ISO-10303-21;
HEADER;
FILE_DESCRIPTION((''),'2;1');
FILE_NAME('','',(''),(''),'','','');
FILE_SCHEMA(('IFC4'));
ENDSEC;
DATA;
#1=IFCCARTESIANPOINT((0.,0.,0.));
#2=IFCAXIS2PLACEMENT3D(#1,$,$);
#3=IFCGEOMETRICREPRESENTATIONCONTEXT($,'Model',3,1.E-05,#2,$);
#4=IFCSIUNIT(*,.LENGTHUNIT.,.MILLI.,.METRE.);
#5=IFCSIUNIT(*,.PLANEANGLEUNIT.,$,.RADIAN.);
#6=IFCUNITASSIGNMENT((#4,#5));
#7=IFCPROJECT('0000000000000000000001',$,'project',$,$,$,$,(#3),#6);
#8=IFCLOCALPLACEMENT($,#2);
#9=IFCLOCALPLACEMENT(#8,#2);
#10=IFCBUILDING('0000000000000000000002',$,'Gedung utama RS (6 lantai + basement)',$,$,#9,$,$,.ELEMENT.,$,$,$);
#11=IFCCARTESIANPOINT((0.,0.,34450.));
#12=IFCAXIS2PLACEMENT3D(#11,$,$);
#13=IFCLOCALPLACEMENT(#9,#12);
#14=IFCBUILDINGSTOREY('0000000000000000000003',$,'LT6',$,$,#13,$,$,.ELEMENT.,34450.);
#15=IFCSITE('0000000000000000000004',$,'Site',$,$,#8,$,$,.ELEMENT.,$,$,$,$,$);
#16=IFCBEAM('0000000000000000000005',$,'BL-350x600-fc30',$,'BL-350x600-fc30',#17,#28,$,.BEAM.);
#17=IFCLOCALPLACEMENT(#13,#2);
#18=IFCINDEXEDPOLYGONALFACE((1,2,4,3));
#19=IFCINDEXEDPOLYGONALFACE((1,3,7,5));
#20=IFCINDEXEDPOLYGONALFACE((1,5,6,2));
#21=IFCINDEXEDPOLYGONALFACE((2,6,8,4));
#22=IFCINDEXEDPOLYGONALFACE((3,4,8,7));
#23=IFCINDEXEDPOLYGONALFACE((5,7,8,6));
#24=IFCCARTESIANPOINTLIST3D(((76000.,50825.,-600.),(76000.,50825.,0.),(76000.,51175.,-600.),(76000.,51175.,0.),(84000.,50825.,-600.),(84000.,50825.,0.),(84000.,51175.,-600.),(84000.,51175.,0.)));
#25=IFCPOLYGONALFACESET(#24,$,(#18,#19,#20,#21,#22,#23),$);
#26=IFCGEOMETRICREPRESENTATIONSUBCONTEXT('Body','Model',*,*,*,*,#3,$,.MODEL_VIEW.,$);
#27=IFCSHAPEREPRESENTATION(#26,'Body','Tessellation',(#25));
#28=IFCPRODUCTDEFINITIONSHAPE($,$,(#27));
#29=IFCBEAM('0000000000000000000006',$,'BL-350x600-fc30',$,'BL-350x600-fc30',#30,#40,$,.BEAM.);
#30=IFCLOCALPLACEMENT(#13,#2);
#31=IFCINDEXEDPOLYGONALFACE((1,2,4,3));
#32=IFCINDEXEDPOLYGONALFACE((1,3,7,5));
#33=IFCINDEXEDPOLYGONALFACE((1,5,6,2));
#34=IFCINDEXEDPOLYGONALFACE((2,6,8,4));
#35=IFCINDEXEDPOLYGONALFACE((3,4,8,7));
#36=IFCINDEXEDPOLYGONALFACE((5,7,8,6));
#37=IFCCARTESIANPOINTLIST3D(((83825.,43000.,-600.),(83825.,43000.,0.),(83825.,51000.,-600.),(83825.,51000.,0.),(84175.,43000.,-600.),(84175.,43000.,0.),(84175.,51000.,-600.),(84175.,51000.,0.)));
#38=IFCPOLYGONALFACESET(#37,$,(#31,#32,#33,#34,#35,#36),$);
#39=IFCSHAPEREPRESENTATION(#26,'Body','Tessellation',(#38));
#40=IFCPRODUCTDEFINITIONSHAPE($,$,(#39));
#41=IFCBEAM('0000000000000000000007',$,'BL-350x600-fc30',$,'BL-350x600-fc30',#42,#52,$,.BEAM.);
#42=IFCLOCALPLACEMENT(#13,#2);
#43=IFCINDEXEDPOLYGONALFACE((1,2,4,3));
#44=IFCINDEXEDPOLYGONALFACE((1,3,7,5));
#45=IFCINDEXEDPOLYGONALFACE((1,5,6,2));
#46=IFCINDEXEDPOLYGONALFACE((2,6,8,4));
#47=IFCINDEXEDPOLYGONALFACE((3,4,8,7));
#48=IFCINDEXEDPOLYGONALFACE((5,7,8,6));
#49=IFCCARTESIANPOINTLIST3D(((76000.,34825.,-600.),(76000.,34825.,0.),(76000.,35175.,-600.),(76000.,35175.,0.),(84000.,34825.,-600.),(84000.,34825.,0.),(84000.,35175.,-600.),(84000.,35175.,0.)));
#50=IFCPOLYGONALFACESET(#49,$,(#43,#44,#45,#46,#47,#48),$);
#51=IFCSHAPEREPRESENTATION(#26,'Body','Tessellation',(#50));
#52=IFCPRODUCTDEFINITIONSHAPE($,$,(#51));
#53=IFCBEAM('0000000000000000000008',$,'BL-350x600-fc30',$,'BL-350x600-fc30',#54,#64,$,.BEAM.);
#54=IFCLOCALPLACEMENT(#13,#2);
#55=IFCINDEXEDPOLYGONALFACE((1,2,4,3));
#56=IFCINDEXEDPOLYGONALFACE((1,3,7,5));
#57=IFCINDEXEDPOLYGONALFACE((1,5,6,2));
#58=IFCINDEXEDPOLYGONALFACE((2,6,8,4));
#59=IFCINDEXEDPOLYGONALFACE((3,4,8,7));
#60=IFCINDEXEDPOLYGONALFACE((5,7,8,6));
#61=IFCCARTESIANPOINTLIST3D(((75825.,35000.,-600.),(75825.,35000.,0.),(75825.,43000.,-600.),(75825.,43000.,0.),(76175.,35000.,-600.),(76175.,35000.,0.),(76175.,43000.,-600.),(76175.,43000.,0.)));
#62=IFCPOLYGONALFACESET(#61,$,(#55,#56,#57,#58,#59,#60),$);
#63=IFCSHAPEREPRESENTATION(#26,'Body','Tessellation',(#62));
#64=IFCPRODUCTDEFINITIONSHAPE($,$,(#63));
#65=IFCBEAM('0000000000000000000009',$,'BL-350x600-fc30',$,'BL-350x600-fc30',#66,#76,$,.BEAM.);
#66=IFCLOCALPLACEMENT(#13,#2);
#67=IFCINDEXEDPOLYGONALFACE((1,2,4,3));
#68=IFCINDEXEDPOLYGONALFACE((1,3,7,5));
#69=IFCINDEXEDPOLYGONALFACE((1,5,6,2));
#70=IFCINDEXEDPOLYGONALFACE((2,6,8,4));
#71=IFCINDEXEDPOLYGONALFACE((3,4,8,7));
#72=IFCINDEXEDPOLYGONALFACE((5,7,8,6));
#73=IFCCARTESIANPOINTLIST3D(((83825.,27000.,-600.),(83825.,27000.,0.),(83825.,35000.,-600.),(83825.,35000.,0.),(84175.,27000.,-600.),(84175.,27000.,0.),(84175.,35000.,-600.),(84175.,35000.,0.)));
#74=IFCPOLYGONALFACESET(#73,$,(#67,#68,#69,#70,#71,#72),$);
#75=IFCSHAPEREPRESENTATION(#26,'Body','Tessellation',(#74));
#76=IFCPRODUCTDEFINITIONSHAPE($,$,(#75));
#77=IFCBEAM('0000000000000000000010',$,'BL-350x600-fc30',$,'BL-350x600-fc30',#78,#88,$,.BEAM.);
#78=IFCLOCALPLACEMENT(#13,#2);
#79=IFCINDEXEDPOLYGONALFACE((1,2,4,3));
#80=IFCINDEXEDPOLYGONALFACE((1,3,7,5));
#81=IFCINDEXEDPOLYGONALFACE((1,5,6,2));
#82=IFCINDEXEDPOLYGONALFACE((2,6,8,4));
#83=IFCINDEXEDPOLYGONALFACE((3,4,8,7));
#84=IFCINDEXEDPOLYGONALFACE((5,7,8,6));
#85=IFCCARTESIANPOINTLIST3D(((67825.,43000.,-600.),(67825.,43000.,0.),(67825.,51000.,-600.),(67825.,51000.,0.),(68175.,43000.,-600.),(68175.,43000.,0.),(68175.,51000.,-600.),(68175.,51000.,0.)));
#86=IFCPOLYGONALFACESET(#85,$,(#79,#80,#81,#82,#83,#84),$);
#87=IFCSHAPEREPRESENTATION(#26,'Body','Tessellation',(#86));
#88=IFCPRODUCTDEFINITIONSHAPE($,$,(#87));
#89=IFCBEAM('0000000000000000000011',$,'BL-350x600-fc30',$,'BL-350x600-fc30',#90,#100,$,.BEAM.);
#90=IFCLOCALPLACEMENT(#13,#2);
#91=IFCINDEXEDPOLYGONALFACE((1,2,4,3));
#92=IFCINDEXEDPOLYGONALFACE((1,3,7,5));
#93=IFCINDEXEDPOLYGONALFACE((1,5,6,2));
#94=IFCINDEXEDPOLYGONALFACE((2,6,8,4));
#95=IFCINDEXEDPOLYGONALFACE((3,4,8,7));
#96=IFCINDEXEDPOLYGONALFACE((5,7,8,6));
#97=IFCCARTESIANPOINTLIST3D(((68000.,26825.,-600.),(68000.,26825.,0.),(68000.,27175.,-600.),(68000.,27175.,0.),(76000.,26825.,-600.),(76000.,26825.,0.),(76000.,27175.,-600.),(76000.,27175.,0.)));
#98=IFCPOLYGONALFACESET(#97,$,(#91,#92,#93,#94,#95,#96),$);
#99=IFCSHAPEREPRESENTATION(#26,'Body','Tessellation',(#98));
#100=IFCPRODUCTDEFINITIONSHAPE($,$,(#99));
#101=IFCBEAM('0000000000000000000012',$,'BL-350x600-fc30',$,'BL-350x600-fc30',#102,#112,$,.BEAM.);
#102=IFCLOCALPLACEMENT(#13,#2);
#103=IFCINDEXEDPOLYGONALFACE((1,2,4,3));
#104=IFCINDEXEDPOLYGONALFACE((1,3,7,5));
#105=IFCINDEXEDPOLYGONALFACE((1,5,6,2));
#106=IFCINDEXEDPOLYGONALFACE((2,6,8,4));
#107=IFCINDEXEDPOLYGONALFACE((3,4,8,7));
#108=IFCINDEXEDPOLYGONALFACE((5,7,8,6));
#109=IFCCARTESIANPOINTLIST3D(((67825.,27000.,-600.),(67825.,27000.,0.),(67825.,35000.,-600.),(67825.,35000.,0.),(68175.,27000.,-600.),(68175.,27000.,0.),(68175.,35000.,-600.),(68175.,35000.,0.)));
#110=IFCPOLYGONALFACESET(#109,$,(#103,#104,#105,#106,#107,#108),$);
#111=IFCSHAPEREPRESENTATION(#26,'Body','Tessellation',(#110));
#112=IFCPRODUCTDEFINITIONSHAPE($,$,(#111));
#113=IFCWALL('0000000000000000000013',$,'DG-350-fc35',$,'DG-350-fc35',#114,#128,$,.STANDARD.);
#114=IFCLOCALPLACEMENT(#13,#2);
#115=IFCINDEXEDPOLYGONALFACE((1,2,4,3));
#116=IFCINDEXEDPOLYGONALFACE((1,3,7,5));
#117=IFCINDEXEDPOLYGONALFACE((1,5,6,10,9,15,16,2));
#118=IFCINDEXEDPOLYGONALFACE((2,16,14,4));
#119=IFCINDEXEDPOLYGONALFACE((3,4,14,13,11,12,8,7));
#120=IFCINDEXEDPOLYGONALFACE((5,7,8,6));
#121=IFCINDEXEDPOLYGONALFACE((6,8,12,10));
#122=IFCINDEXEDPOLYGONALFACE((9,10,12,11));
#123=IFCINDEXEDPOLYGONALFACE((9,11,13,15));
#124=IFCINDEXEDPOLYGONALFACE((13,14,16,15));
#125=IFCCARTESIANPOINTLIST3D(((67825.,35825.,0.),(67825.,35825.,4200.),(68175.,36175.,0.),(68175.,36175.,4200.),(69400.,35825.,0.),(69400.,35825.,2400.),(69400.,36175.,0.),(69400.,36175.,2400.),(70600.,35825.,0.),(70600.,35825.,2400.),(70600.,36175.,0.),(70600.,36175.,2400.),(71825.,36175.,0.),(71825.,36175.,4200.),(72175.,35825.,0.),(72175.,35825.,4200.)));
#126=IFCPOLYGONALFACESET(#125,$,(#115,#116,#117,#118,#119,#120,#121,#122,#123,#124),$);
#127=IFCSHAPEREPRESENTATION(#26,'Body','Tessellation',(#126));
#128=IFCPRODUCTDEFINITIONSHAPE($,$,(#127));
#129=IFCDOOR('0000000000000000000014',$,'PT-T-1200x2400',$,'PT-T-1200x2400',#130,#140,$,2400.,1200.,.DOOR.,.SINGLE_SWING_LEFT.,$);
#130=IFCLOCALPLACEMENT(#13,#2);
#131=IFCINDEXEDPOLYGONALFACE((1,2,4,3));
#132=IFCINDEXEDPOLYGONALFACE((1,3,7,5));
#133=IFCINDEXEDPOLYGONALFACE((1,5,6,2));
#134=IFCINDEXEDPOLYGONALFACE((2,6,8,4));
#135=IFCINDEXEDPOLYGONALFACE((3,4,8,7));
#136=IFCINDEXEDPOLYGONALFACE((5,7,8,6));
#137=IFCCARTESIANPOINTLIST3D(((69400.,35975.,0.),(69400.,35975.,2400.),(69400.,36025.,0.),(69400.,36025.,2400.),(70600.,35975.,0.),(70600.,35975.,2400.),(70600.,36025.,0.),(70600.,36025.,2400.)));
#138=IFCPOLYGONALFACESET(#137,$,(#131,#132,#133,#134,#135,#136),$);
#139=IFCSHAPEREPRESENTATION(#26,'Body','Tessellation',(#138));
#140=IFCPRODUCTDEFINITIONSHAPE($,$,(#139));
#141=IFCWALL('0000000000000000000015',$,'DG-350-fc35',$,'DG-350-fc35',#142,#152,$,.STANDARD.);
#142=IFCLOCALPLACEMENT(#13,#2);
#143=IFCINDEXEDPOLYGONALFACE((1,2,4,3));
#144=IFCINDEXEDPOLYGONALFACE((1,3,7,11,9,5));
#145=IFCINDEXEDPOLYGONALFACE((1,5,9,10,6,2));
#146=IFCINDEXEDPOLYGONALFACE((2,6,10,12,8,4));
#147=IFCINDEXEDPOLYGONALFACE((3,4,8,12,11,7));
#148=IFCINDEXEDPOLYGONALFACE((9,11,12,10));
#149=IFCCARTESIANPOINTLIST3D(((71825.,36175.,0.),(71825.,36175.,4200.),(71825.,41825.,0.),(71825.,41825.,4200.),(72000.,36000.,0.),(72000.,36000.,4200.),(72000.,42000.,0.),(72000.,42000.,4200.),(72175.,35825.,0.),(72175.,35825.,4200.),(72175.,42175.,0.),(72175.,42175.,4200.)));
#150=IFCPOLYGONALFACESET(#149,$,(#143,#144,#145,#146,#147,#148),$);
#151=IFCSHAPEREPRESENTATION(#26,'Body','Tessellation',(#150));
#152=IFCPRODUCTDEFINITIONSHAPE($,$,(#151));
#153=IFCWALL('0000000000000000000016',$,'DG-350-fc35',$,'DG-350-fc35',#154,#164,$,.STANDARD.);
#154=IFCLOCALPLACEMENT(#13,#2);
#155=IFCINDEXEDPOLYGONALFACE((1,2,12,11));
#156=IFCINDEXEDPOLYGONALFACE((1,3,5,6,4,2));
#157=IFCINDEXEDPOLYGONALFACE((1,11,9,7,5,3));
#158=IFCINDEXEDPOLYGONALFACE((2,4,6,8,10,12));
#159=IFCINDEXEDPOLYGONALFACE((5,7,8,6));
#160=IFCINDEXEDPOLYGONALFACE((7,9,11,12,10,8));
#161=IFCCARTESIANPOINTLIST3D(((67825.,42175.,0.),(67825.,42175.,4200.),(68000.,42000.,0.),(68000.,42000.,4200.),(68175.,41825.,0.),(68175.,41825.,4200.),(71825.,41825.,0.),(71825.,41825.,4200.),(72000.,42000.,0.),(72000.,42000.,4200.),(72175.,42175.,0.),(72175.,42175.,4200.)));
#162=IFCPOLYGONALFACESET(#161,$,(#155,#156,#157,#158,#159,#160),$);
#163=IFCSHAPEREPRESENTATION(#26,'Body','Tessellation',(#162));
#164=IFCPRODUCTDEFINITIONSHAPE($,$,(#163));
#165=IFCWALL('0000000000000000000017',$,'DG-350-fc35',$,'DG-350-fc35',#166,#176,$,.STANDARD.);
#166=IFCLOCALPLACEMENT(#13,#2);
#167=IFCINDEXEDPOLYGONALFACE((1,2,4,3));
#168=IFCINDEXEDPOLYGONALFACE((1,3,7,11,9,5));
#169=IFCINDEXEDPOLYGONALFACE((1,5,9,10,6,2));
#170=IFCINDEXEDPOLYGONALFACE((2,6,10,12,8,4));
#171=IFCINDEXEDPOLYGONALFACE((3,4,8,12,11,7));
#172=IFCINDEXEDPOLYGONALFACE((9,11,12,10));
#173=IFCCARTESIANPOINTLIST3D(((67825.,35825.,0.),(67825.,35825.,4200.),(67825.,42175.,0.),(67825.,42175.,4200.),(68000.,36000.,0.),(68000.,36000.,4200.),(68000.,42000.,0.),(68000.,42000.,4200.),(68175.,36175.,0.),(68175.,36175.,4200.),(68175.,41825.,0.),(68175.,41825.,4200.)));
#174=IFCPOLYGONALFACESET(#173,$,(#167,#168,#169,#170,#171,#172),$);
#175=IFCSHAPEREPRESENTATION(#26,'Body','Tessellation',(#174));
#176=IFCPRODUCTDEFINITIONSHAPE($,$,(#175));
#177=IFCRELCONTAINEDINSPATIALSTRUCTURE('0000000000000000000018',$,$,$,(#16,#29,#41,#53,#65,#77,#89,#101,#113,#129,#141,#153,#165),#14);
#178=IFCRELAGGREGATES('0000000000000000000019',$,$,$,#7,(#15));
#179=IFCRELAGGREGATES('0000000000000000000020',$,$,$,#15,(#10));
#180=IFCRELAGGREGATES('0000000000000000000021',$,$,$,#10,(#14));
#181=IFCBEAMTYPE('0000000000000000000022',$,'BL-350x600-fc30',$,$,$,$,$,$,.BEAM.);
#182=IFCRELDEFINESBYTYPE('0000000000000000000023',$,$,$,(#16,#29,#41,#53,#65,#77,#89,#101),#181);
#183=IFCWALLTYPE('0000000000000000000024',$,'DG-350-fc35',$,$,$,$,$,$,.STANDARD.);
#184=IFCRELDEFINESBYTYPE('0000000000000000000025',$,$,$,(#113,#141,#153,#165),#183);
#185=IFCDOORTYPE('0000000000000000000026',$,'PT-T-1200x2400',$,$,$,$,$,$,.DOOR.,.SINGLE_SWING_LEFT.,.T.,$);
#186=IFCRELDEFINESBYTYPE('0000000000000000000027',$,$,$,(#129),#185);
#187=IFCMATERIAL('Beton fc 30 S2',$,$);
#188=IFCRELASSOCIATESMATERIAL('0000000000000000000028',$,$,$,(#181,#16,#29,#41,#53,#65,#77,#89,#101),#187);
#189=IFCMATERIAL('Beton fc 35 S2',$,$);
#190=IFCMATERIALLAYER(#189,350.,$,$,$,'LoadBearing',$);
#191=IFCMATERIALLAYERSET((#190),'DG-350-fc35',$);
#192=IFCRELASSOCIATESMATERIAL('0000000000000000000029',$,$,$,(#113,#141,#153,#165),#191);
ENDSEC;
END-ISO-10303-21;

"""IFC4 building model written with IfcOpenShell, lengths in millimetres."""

from ifc_helpers import new_model, si_unit, frame, frame_2d, origin, origin_2d, place, context, subcontext, project, spatial, polyline, rectangle, outline, extrude, material, layer, layer_set, layer_usage, material_profile, profile_set, profile_usage, type_object, element, fill, save


model = new_model("IFC4")

# Units and contexts
model_context = context("Model", 3, precision=1e-05, world=origin())
body_context = subcontext(model_context, "Body", "Model", "MODEL_VIEW")
ifc_project = project(units=[si_unit("LENGTHUNIT", "METRE", prefix="MILLI"), si_unit("PLANEANGLEUNIT", "RADIAN")], contexts=[model_context])

# Site, building, storey
site_placement = place(None, origin())
site = spatial("IfcSite", under=ifc_project, at=site_placement, Name="Site", CompositionType="ELEMENT")
building_placement = place(site_placement, origin())
building = spatial("IfcBuilding", under=site, at=building_placement, Name="Gedung utama RS (6 lantai + basement)", CompositionType="ELEMENT")
storey_placement = place(building_placement, frame((0.0, 0.0, 34450.0)))
storey = spatial("IfcBuildingStorey", under=building, at=storey_placement, Name="LT6", CompositionType="ELEMENT", Elevation=34450.0)

# Beams
ifc_material_1 = material(Name="Beton fc 30 S2")
ifc_material_profile_1 = material_profile(ifc_material_1, rectangle(XDim=350.0, YDim=600.0, at=origin_2d()), Name="BL-350x600-fc30")
ifc_profile_set_1 = profile_set([ifc_material_profile_1], Name="BL-350x600-fc30")
ifc_profile_usage_1 = profile_usage(ifc_profile_set_1, cardinal=8)
beam_type = type_object("IfcBeamType", Name="BL-350x600-fc30", PredefinedType="BEAM", material=ifc_profile_set_1)
beam_1_placement = place(storey_placement, frame((76000.0, 51000.0, -300.0)))
element("IfcBeam", 1, at=beam_1_placement, inside=storey, type_object=beam_type, material=ifc_profile_usage_1, Name="BL-350x600-fc30", ObjectType="BL-350x600-fc30", PredefinedType="BEAM", context=body_context, shape_type="SweptSolid", body=[
    extrude(rectangle(XDim=350.0, YDim=600.0, at=origin_2d()), frame((0.0, 0.0, 0.0), z_axis=(1.0, 0.0, 0.0), x_axis=(0.0, 1.0, 0.0)), (0.0, 0.0, 1.0), 8000.0),
])
beam_2_placement = place(storey_placement, frame((84000.0, 43000.0, -300.0)))
element("IfcBeam", 2, at=beam_2_placement, inside=storey, type_object=beam_type, material=ifc_profile_usage_1, Name="BL-350x600-fc30", ObjectType="BL-350x600-fc30", PredefinedType="BEAM", context=body_context, shape_type="SweptSolid", body=[
    extrude(rectangle(XDim=350.0, YDim=600.0, at=origin_2d()), frame((0.0, 0.0, 0.0), z_axis=(0.0, 1.0, 0.0), x_axis=(-1.0, 0.0, 0.0)), (0.0, 0.0, 1.0), 8000.0),
])
beam_3_placement = place(storey_placement, frame((76000.0, 35000.0, -300.0)))
element("IfcBeam", 3, at=beam_3_placement, inside=storey, type_object=beam_type, material=ifc_profile_usage_1, Name="BL-350x600-fc30", ObjectType="BL-350x600-fc30", PredefinedType="BEAM", context=body_context, shape_type="SweptSolid", body=[
    extrude(rectangle(XDim=350.0, YDim=600.0, at=origin_2d()), frame((0.0, 0.0, 0.0), z_axis=(1.0, 0.0, 0.0), x_axis=(0.0, 1.0, 0.0)), (0.0, 0.0, 1.0), 8000.0),
])
for number, where, name in (
    (4, (76000.0, 35000.0, -300.0), "BL-350x600-fc30"),
    (5, (84000.0, 27000.0, -300.0), "BL-350x600-fc30"),
    (6, (68000.0, 43000.0, -300.0), "BL-350x600-fc30"),
):
    element("IfcBeam", number, at=place(storey_placement, frame(where)), inside=storey, type_object=beam_type, material=ifc_profile_usage_1, Name=name, ObjectType="BL-350x600-fc30", PredefinedType="BEAM", context=body_context, shape_type="SweptSolid", body=[
        extrude(rectangle(XDim=350.0, YDim=600.0, at=origin_2d()), frame((0.0, 0.0, 0.0), z_axis=(0.0, 1.0, 0.0), x_axis=(-1.0, 0.0, 0.0)), (0.0, 0.0, 1.0), 8000.0),
    ])
beam_4_placement = place(storey_placement, frame((68000.0, 27000.0, -300.0)))
element("IfcBeam", 7, at=beam_4_placement, inside=storey, type_object=beam_type, material=ifc_profile_usage_1, Name="BL-350x600-fc30", ObjectType="BL-350x600-fc30", PredefinedType="BEAM", context=body_context, shape_type="SweptSolid", body=[
    extrude(rectangle(XDim=350.0, YDim=600.0, at=origin_2d()), frame((0.0, 0.0, 0.0), z_axis=(1.0, 0.0, 0.0), x_axis=(0.0, 1.0, 0.0)), (0.0, 0.0, 1.0), 8000.0),
])
beam_5_placement = place(storey_placement, frame((68000.0, 27000.0, -300.0)))
element("IfcBeam", 8, at=beam_5_placement, inside=storey, type_object=beam_type, material=ifc_profile_usage_1, Name="BL-350x600-fc30", ObjectType="BL-350x600-fc30", PredefinedType="BEAM", context=body_context, shape_type="SweptSolid", body=[
    extrude(rectangle(XDim=350.0, YDim=600.0, at=origin_2d()), frame((0.0, 0.0, 0.0), z_axis=(0.0, 1.0, 0.0), x_axis=(-1.0, 0.0, 0.0)), (0.0, 0.0, 1.0), 8000.0),
])

# Wall, opening, door
ifc_material_2 = material(Name="Beton fc 35 S2")
ifc_layer_1 = layer(ifc_material_2, 350.0, Category="LoadBearing")
ifc_layer_set_1 = layer_set([ifc_layer_1], Name="DG-350-fc35")
ifc_layer_usage_1 = layer_usage(ifc_layer_set_1, "AXIS2", "NEGATIVE", 175.0)
wall_type_1 = type_object("IfcWallType", Name="DG-350-fc35", PredefinedType="STANDARD")
wall_1_placement = place(storey_placement, frame((68000.0, 36000.0, 0.0), z_axis=(0.0, 0.0, 1.0), x_axis=(1.0, 0.0, 0.0)))
wall_1 = element("IfcWall", 9, at=wall_1_placement, inside=storey, type_object=wall_type_1, material=ifc_layer_usage_1, Name="DG-350-fc35", ObjectType="DG-350-fc35", PredefinedType="STANDARD", context=body_context, shape_type="SweptSolid", body=[
    extrude(outline(polyline([(-175.0, -175.0), (0.0, 0.0), (175.0, 175.0), (3825.0, 175.0), (4000.0, 0.0), (4175.0, -175.0), (-175.0, -175.0)])), origin(), (0.0, 0.0, 1.0), 4200.0),
])
opening_placement = place(wall_1_placement, frame((1400.0, 0.0, 0.0), z_axis=(0.0, 0.0, 1.0), x_axis=(1.0, 0.0, 0.0)))
opening = element("IfcOpeningElement", 10, at=opening_placement, cuts=wall_1, PredefinedType="OPENING", context=body_context, shape_type="SweptSolid", body=[
    extrude(rectangle(XDim=1200.0, YDim=370.0, at=frame_2d((600.0, 0.0))), origin(), (0.0, 0.0, 1.0), 2400.0),
])
door_type = type_object("IfcDoorType", Name="PT-T-1200x2400", OperationType="SINGLE_SWING_LEFT", ParameterTakesPrecedence=True, PredefinedType="DOOR")
door_placement = place(opening_placement, origin())
door = element("IfcDoor", 11, at=door_placement, inside=storey, type_object=door_type, Name="PT-T-1200x2400", ObjectType="PT-T-1200x2400", OperationType="SINGLE_SWING_LEFT", OverallHeight=2400.0, OverallWidth=1200.0, PredefinedType="DOOR", context=body_context, shape_type="SweptSolid", body=[
    extrude(rectangle(XDim=1200.0, YDim=50.0, at=frame_2d((600.0, 0.0))), origin(), (0.0, 0.0, 1.0), 2400.0),
])
fill(opening, door)

# Walls
wall_2_placement = place(storey_placement, frame((72000.0, 36000.0, 0.0), z_axis=(0.0, 0.0, 1.0), x_axis=(0.0, 1.0, 0.0)))
element("IfcWall", 12, at=wall_2_placement, inside=storey, type_object=wall_type_1, material=ifc_layer_usage_1, Name="DG-350-fc35", ObjectType="DG-350-fc35", PredefinedType="STANDARD", context=body_context, shape_type="SweptSolid", body=[
    extrude(outline(polyline([(-175.0, -175.0), (0.0, 0.0), (175.0, 175.0), (5825.0, 175.0), (6000.0, 0.0), (6175.0, -175.0), (-175.0, -175.0)])), origin(), (0.0, 0.0, 1.0), 4200.0),
])
wall_3_placement = place(storey_placement, frame((72000.0, 42000.0, 0.0), z_axis=(0.0, 0.0, 1.0), x_axis=(-1.0, 0.0, 0.0)))
element("IfcWall", 13, at=wall_3_placement, inside=storey, type_object=wall_type_1, material=ifc_layer_usage_1, Name="DG-350-fc35", ObjectType="DG-350-fc35", PredefinedType="STANDARD", context=body_context, shape_type="SweptSolid", body=[
    extrude(outline(polyline([(-175.0, -175.0), (0.0, 0.0), (175.0, 175.0), (3825.0, 175.0), (4000.0, 0.0), (4175.0, -175.0), (-175.0, -175.0)])), origin(), (0.0, 0.0, 1.0), 4200.0),
])
wall_4_placement = place(storey_placement, frame((68000.0, 42000.0, 0.0), z_axis=(0.0, 0.0, 1.0), x_axis=(0.0, -1.0, 0.0)))
element("IfcWall", 14, at=wall_4_placement, inside=storey, type_object=wall_type_1, material=ifc_layer_usage_1, Name="DG-350-fc35", ObjectType="DG-350-fc35", PredefinedType="STANDARD", context=body_context, shape_type="SweptSolid", body=[
    extrude(outline(polyline([(-175.0, -175.0), (0.0, 0.0), (175.0, 175.0), (5825.0, 175.0), (6000.0, 0.0), (6175.0, -175.0), (-175.0, -175.0)])), origin(), (0.0, 0.0, 1.0), 4200.0),
])

save(model, "model.ifc")
